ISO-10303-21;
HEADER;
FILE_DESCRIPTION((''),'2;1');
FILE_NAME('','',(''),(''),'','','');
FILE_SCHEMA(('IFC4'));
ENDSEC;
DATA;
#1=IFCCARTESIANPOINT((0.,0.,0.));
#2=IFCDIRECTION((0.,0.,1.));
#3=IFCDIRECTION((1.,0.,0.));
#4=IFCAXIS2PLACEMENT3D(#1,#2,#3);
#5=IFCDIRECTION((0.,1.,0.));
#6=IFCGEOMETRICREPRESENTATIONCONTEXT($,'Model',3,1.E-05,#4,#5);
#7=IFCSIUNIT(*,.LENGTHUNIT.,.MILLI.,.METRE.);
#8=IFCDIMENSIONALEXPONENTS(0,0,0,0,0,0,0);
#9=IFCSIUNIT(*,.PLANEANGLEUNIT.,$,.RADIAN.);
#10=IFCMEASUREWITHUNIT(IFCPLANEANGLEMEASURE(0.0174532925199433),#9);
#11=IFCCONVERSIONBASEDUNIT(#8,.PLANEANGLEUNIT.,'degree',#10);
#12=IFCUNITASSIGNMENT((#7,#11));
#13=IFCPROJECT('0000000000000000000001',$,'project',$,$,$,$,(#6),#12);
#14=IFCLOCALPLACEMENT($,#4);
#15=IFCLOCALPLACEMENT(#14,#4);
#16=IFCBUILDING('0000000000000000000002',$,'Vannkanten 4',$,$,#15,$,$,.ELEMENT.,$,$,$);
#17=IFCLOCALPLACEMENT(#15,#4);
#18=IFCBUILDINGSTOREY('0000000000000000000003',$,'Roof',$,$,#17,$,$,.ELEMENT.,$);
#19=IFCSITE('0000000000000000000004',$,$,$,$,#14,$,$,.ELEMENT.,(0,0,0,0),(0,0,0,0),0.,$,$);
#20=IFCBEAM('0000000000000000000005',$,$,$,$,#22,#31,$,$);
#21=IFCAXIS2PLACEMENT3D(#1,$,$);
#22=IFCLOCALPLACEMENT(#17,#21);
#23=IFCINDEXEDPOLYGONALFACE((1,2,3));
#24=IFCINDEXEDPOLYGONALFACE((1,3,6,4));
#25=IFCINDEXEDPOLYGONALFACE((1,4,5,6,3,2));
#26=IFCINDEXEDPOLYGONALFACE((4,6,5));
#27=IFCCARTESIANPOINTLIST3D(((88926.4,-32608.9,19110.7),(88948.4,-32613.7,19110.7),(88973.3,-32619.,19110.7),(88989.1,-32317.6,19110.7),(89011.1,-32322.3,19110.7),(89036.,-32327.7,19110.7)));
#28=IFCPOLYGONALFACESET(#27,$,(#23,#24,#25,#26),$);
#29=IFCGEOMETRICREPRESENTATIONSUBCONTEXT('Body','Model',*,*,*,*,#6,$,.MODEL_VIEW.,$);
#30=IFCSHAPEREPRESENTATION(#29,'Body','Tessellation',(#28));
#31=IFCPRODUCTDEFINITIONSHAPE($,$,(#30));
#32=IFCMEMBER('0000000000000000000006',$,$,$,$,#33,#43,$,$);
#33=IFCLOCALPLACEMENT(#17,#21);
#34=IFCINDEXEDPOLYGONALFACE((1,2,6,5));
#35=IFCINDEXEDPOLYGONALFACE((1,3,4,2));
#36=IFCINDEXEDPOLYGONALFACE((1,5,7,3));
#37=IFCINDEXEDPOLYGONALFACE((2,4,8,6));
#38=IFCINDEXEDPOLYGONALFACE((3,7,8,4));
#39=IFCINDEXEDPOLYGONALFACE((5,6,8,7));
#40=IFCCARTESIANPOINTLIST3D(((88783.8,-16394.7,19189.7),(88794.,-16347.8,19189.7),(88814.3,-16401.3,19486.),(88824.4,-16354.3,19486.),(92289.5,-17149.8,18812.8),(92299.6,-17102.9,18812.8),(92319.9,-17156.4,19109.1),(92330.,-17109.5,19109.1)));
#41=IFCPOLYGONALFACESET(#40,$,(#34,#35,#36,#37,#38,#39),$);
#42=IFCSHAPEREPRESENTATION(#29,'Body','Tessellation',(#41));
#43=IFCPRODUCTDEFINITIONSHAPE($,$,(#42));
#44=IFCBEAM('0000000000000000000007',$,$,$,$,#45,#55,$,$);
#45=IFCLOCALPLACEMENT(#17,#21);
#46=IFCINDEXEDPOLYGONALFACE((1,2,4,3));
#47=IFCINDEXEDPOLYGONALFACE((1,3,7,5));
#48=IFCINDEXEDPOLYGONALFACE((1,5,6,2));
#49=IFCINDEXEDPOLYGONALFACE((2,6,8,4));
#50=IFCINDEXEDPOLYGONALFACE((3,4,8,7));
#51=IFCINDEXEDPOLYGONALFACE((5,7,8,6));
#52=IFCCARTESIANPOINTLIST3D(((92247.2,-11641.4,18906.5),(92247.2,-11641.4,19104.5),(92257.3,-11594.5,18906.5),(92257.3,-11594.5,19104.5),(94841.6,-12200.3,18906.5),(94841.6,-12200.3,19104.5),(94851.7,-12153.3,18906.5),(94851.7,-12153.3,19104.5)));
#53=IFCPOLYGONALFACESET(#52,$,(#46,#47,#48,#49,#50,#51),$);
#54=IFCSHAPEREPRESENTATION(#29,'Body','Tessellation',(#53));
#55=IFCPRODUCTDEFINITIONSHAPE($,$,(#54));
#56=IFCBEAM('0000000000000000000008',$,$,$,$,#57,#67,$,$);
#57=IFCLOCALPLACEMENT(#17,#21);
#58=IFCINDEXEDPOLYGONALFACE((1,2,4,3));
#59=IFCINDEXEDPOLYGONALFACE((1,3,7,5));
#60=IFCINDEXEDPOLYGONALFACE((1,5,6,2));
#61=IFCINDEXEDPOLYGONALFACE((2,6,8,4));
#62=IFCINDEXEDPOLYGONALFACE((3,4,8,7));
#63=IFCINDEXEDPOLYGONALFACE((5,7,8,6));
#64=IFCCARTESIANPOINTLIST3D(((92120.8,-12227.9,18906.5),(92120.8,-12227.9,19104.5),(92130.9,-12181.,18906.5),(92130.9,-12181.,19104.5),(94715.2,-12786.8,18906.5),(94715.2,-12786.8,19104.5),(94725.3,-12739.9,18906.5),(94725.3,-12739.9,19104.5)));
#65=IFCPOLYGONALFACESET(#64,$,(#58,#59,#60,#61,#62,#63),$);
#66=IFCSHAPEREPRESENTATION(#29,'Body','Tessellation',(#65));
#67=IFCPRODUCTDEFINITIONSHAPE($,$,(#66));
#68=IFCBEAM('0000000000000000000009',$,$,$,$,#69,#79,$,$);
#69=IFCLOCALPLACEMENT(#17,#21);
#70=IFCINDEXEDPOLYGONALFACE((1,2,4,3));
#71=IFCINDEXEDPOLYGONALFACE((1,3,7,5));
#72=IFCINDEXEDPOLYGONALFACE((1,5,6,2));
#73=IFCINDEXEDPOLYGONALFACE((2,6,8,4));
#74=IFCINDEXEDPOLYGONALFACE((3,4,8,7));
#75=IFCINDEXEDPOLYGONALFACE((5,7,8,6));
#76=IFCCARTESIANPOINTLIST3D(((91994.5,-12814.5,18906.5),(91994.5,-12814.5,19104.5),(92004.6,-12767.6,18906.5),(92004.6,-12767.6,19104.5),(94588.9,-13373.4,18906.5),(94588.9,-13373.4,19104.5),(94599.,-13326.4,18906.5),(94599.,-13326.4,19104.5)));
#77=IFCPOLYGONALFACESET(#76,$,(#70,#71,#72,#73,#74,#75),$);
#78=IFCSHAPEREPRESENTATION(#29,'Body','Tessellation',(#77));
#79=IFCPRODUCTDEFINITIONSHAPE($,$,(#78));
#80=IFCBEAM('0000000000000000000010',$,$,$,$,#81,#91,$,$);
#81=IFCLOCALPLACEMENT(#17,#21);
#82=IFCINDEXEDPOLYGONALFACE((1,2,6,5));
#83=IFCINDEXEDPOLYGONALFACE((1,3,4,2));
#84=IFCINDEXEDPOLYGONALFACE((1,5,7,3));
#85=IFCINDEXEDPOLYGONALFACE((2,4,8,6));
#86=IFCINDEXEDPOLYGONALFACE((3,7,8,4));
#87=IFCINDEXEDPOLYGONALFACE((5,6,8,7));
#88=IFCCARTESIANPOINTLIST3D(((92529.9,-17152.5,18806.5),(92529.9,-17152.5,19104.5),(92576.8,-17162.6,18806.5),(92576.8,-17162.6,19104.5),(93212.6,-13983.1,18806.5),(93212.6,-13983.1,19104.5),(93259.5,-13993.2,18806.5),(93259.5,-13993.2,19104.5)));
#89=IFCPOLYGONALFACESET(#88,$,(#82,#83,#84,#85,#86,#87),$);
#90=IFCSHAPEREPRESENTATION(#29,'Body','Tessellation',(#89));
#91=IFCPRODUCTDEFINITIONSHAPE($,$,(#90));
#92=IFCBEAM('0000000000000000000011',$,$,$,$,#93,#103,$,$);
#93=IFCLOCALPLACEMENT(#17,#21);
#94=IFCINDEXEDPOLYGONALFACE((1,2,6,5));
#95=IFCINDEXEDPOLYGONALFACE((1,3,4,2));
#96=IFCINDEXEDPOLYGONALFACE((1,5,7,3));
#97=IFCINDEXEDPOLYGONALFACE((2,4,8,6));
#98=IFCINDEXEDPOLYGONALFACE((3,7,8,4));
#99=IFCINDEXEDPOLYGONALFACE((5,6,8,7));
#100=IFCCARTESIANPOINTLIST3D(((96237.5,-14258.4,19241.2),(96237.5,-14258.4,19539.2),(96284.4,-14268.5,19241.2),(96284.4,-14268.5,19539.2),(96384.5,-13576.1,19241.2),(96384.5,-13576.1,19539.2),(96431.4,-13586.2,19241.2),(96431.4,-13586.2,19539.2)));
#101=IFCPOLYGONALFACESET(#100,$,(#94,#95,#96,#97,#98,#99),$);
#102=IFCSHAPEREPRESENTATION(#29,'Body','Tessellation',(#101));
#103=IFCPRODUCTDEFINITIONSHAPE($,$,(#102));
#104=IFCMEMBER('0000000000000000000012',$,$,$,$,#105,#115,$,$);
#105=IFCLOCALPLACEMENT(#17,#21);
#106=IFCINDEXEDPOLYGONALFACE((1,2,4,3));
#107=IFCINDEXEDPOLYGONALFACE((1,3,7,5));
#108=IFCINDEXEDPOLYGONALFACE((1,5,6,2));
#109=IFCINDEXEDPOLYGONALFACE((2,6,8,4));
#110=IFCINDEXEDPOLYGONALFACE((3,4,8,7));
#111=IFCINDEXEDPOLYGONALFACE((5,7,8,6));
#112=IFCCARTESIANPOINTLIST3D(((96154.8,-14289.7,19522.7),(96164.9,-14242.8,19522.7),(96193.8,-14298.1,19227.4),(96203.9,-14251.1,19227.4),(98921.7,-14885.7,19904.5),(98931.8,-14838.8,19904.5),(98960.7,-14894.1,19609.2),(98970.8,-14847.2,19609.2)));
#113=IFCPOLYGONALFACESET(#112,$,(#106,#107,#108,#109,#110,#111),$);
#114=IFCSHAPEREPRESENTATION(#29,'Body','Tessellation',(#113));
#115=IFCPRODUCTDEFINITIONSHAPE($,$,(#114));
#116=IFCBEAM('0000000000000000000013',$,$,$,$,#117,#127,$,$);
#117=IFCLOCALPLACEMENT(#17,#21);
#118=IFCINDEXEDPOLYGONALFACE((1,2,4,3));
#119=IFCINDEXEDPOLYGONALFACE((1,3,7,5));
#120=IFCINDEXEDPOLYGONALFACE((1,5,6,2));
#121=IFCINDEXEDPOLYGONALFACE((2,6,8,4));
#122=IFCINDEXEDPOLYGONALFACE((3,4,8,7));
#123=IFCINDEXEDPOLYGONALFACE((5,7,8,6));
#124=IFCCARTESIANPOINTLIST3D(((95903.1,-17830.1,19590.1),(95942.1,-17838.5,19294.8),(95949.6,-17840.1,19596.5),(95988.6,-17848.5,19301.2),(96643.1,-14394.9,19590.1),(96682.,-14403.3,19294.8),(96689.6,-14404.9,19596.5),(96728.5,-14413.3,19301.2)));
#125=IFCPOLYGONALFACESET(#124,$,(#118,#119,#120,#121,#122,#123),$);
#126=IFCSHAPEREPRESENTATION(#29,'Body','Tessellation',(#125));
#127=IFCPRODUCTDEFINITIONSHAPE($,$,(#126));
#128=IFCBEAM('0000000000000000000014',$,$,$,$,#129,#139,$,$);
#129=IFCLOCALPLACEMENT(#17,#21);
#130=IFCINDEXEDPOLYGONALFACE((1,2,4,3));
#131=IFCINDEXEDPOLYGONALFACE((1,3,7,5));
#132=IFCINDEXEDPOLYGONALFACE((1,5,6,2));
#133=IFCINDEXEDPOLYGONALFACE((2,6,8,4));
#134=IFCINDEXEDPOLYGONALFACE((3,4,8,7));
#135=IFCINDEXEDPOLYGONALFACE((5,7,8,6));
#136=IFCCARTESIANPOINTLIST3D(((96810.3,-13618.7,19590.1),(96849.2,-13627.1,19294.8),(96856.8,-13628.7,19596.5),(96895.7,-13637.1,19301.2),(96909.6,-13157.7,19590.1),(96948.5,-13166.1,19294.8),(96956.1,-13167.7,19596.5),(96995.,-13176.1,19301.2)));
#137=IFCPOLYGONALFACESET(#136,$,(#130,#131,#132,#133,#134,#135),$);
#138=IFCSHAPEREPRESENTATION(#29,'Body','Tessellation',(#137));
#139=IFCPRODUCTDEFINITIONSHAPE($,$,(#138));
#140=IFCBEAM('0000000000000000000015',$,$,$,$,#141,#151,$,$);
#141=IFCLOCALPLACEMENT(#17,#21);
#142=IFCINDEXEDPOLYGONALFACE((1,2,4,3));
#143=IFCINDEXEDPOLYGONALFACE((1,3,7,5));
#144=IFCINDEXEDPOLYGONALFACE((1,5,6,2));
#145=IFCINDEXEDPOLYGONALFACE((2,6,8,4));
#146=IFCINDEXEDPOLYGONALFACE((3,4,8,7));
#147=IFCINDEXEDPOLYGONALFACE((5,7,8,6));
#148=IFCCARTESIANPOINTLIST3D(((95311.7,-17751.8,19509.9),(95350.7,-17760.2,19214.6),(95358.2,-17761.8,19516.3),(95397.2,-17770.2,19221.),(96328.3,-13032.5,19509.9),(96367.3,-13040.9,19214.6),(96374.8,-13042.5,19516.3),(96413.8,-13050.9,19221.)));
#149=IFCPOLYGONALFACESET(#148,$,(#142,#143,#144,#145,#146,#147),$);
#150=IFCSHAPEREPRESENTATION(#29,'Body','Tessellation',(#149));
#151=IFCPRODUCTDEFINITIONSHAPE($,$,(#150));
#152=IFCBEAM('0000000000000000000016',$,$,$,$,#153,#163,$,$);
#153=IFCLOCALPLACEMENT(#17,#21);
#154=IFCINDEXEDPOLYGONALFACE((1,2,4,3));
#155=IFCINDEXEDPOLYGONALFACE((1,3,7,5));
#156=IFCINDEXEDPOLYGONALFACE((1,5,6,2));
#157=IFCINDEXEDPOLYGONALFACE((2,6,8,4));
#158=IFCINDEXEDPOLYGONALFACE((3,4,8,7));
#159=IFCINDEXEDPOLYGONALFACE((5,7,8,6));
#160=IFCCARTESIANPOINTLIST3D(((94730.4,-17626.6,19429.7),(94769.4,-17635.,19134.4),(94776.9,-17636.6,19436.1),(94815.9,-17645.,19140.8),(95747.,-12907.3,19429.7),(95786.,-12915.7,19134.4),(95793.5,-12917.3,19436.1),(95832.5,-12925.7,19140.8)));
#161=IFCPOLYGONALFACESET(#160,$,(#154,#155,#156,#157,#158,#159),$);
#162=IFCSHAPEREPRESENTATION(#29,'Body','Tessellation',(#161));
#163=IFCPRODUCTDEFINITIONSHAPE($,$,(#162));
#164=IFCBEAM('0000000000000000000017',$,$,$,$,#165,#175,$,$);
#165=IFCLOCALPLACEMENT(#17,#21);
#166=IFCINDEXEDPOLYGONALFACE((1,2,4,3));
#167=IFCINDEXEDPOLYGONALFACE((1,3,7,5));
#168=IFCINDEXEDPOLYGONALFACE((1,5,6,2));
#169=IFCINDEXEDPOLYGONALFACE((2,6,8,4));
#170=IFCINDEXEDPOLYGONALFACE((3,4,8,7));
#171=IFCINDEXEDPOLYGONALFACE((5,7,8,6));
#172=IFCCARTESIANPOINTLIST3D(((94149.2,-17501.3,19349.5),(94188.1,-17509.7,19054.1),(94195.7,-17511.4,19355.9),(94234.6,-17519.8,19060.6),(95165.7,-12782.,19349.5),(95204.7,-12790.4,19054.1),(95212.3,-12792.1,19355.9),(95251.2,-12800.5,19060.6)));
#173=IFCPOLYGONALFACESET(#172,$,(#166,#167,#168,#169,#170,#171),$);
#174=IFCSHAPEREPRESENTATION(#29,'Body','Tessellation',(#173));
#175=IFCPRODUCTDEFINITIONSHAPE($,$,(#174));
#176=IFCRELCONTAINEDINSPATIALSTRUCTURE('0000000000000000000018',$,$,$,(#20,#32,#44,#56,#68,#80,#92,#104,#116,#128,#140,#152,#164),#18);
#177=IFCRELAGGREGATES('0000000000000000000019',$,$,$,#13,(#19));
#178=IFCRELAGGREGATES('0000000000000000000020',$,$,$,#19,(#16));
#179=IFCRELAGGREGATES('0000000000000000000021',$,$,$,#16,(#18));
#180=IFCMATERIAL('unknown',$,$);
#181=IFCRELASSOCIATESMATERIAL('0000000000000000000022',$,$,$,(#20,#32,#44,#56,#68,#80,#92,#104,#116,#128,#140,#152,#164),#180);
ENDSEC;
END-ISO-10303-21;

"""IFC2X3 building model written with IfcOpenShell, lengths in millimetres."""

from ifc_helpers import new_model, entity, si_unit, converted_unit, direction, frame, origin_with_axes, place, context, subcontext, project, spatial, polyline, segment, composite_curve, outline, extrude, material, element, save


model = new_model("IFC2X3")

# Units and contexts
model_context = context("Model", 3, precision=1e-05, world=origin_with_axes(), true_north=direction((0.0, 1.0, 0.0)))
body_context = subcontext(model_context, "Body", "Model", "MODEL_VIEW")
ifc_project = project(units=[si_unit("LENGTHUNIT", "METRE", prefix="MILLI"), converted_unit("PLANEANGLEUNIT", "degree", entity("IfcPlaneAngleMeasure", 0.0174532925199433), si_unit("PLANEANGLEUNIT", "RADIAN"), dimensions=[0, 0, 0, 0, 0, 0, 0])], contexts=[model_context])

# Site, building, storey
site_placement = place(None, origin_with_axes())
site = spatial("IfcSite", under=ifc_project, at=site_placement, CompositionType="ELEMENT", RefLatitude=(0, 0, 0, 0), RefLongitude=(0, 0, 0, 0), RefElevation=0.0)
building_placement = place(site_placement, origin_with_axes())
building = spatial("IfcBuilding", under=site, at=building_placement, Name="Vannkanten 4", CompositionType="ELEMENT")
storey_placement = place(building_placement, origin_with_axes())
storey = spatial("IfcBuildingStorey", under=building, at=storey_placement, Name="Roof", CompositionType="ELEMENT")

# Shared definitions
ifc_material = material(Name="unknown")

# Beam
beam_1_placement = place(storey_placement, frame((92974.0, -13931.7, 18961.8), z_axis=(-0.210573, -0.977578, -0.000001), x_axis=(0.977578, -0.210573, 0.0)))
element("IfcBeam", 1, at=beam_1_placement, inside=storey, material=ifc_material, context=body_context, shape_type="SweptSolid", body=[
    extrude(outline(composite_curve([segment(polyline([(24.0, 149.0), (1.5, 149.0), (-24.0, 149.0), (-24.0, 149.0), (24.0, 149.0), (24.0, 149.0)]), True, "CONTINUOUS")], self_intersect=False)), frame((0.0, 0.0, 19110.8), z_axis=(0.0, 0.000001, -1.0), x_axis=(-1.0, 0.0, 0.0)), (0.0, 0.0, 1.0), 298.0),
])

# Member
member_1_placement = place(storey_placement, frame((92309.7, -17129.7, 18961.0), z_axis=(-0.972221, 0.209428, 0.104528), x_axis=(-0.210582, -0.977576, 0.0)))
element("IfcMember", 2, at=member_1_placement, inside=storey, material=ifc_material, context=body_context, shape_type="SweptSolid", body=[
    extrude(outline(composite_curve([segment(polyline([(-24.0, -149.0), (-24.0, 149.0), (24.0, 149.0), (24.0, -149.0), (-24.0, -149.0)]), True, "CONTINUOUS")], self_intersect=False)), frame((0.0, 0.0, 0.0), z_axis=(0.0, 0.0, 1.0), x_axis=(1.0, 0.0, 0.0)), (0.0, 0.0, 1.0), 3605.8),
])

# Beams
beam_2_placement = place(storey_placement, frame((94846.6, -12176.8, 19005.5), z_axis=(-0.977576, 0.210582, 0.0), x_axis=(-0.210582, -0.977576, 0.0)))
element("IfcBeam", 3, at=beam_2_placement, inside=storey, material=ifc_material, context=body_context, shape_type="SweptSolid", body=[
    extrude(outline(composite_curve([segment(polyline([(-24.0, -99.0), (-24.0, 99.0), (24.0, 99.0), (24.0, -99.0), (-24.0, -99.0)]), True, "CONTINUOUS")], self_intersect=False)), frame((0.0, 0.0, 0.0), z_axis=(0.0, 0.0, 1.0), x_axis=(1.0, 0.0, 0.0)), (0.0, 0.0, 1.0), 2653.9),
])
beam_3_placement = place(storey_placement, frame((94720.3, -12763.3, 19005.5), z_axis=(-0.977576, 0.210582, 0.0), x_axis=(-0.210582, -0.977576, 0.0)))
element("IfcBeam", 4, at=beam_3_placement, inside=storey, material=ifc_material, context=body_context, shape_type="SweptSolid", body=[
    extrude(outline(composite_curve([segment(polyline([(-24.0, -99.0), (-24.0, 99.0), (24.0, 99.0), (24.0, -99.0), (-24.0, -99.0)]), True, "CONTINUOUS")], self_intersect=False)), frame((0.0, 0.0, 0.0), z_axis=(0.0, 0.0, 1.0), x_axis=(1.0, 0.0, 0.0)), (0.0, 0.0, 1.0), 2653.9),
])
beam_4_placement = place(storey_placement, frame((94593.9, -13349.9, 19005.5), z_axis=(-0.977576, 0.210582, 0.0), x_axis=(-0.210582, -0.977576, 0.0)))
element("IfcBeam", 5, at=beam_4_placement, inside=storey, material=ifc_material, context=body_context, shape_type="SweptSolid", body=[
    extrude(outline(composite_curve([segment(polyline([(-24.0, -99.0), (-24.0, 99.0), (24.0, 99.0), (24.0, -99.0), (-24.0, -99.0)]), True, "CONTINUOUS")], self_intersect=False)), frame((0.0, 0.0, 0.0), z_axis=(0.0, 0.0, 1.0), x_axis=(1.0, 0.0, 0.0)), (0.0, 0.0, 1.0), 2653.9),
])
beam_5_placement = place(storey_placement, frame((92553.3, -17157.6, 18955.5), z_axis=(0.210573, 0.977578, -0.000001), x_axis=(-0.977578, 0.210573, 0.0)))
element("IfcBeam", 6, at=beam_5_placement, inside=storey, material=ifc_material, context=body_context, shape_type="SweptSolid", body=[
    extrude(outline(composite_curve([segment(polyline([(-24.0, -149.0), (-24.0, 149.0), (24.0, 149.0), (24.0, -149.0), (-24.0, -149.0)]), True, "CONTINUOUS")], self_intersect=False)), frame((0.0, 0.0, 0.0), z_axis=(0.0, 0.0, 1.0), x_axis=(1.0, 0.0, 0.0)), (0.0, 0.0, 1.0), 3242.2),
])
beam_6_placement = place(storey_placement, frame((96408.0, -13581.1, 19390.2), z_axis=(-0.210582, -0.977576, 0.0), x_axis=(0.977576, -0.210582, 0.0)))
element("IfcBeam", 7, at=beam_6_placement, inside=storey, material=ifc_material, context=body_context, shape_type="SweptSolid", body=[
    extrude(outline(composite_curve([segment(polyline([(-24.0, -149.0), (-24.0, 149.0), (24.0, 149.0), (24.0, -149.0), (-24.0, -149.0)]), True, "CONTINUOUS")], self_intersect=False)), origin_with_axes(), (0.0, 0.0, 1.0), 698.0),
])

# Member
member_2_placement = place(storey_placement, frame((96179.3, -14270.4, 19375.1), z_axis=(0.968803, -0.208692, 0.133675), x_axis=(0.210582, 0.977576, 0.0)))
element("IfcMember", 8, at=member_2_placement, inside=storey, material=ifc_material, context=body_context, shape_type="SweptSolid", body=[
    extrude(outline(composite_curve([segment(polyline([(-24.0, -149.0), (-24.0, 149.0), (24.0, 149.0), (24.0, -149.0), (-24.0, -149.0)]), True, "CONTINUOUS")], self_intersect=False)), frame((0.0, 0.0, 0.0), z_axis=(0.0, 0.0, 1.0), x_axis=(1.0, 0.0, 0.0)), (0.0, 0.0, 1.0), 2856.0),
])

# Beams
beam_7_placement = place(storey_placement, frame((95945.8, -17839.3, 19445.6), z_axis=(0.210582, 0.977576, 0.0), x_axis=(-0.968803, 0.208692, -0.133675)))
element("IfcBeam", 9, at=beam_7_placement, inside=storey, material=ifc_material, context=body_context, shape_type="SweptSolid", body=[
    extrude(outline(composite_curve([segment(polyline([(-24.0, -149.0), (-24.0, 149.0), (24.0, 149.0), (24.0, -149.0), (-24.0, -149.0)]), True, "CONTINUOUS")], self_intersect=False)), frame((0.0, 0.0, 0.0), z_axis=(0.0, 0.0, 1.0), x_axis=(1.0, 0.0, 0.0)), (0.0, 0.0, 1.0), 3514.0),
])
beam_8_placement = place(storey_placement, frame((96853.0, -13627.9, 19445.6), z_axis=(0.210582, 0.977576, 0.0), x_axis=(-0.968803, 0.208692, -0.133675)))
element("IfcBeam", 10, at=beam_8_placement, inside=storey, material=ifc_material, context=body_context, shape_type="SweptSolid", body=[
    extrude(outline(composite_curve([segment(polyline([(-24.0, -149.0), (-24.0, 149.0), (24.0, 149.0), (24.0, -149.0), (-24.0, -149.0)]), True, "CONTINUOUS")], self_intersect=False)), frame((0.0, 0.0, 0.0), z_axis=(0.0, 0.0, 1.0), x_axis=(1.0, 0.0, 0.0)), (0.0, 0.0, 1.0), 471.5),
])
beam_9_placement = place(storey_placement, frame((95354.4, -17761.0, 19365.4), z_axis=(0.210582, 0.977576, 0.0), x_axis=(-0.968803, 0.208692, -0.133675)))
element("IfcBeam", 11, at=beam_9_placement, inside=storey, material=ifc_material, context=body_context, shape_type="SweptSolid", body=[
    extrude(outline(composite_curve([segment(polyline([(-24.0, -149.0), (-24.0, 149.0), (24.0, 149.0), (24.0, -149.0), (-24.0, -149.0)]), True, "CONTINUOUS")], self_intersect=False)), frame((0.0, 0.0, 0.0), z_axis=(0.0, 0.0, 1.0), x_axis=(1.0, 0.0, 0.0)), (0.0, 0.0, 1.0), 4827.6),
])
beam_10_placement = place(storey_placement, frame((94773.2, -17635.8, 19285.2), z_axis=(0.210582, 0.977576, 0.0), x_axis=(-0.968803, 0.208692, -0.133675)))
element("IfcBeam", 12, at=beam_10_placement, inside=storey, material=ifc_material, context=body_context, shape_type="SweptSolid", body=[
    extrude(outline(composite_curve([segment(polyline([(-24.0, -149.0), (-24.0, 149.0), (24.0, 149.0), (24.0, -149.0), (-24.0, -149.0)]), True, "CONTINUOUS")], self_intersect=False)), frame((0.0, 0.0, 0.0), z_axis=(0.0, 0.0, 1.0), x_axis=(1.0, 0.0, 0.0)), (0.0, 0.0, 1.0), 4827.6),
])
beam_11_placement = place(storey_placement, frame((94191.9, -17510.6, 19205.0), z_axis=(0.210582, 0.977576, 0.0), x_axis=(-0.968803, 0.208692, -0.133675)))
element("IfcBeam", 13, at=beam_11_placement, inside=storey, material=ifc_material, context=body_context, shape_type="SweptSolid", body=[
    extrude(outline(composite_curve([segment(polyline([(-24.0, -149.0), (-24.0, 149.0), (24.0, 149.0), (24.0, -149.0), (-24.0, -149.0)]), True, "CONTINUOUS")], self_intersect=False)), frame((0.0, 0.0, 0.0), z_axis=(0.0, 0.0, 1.0), x_axis=(1.0, 0.0, 0.0)), (0.0, 0.0, 1.0), 4827.6),
])

save(model, "model.ifc")
